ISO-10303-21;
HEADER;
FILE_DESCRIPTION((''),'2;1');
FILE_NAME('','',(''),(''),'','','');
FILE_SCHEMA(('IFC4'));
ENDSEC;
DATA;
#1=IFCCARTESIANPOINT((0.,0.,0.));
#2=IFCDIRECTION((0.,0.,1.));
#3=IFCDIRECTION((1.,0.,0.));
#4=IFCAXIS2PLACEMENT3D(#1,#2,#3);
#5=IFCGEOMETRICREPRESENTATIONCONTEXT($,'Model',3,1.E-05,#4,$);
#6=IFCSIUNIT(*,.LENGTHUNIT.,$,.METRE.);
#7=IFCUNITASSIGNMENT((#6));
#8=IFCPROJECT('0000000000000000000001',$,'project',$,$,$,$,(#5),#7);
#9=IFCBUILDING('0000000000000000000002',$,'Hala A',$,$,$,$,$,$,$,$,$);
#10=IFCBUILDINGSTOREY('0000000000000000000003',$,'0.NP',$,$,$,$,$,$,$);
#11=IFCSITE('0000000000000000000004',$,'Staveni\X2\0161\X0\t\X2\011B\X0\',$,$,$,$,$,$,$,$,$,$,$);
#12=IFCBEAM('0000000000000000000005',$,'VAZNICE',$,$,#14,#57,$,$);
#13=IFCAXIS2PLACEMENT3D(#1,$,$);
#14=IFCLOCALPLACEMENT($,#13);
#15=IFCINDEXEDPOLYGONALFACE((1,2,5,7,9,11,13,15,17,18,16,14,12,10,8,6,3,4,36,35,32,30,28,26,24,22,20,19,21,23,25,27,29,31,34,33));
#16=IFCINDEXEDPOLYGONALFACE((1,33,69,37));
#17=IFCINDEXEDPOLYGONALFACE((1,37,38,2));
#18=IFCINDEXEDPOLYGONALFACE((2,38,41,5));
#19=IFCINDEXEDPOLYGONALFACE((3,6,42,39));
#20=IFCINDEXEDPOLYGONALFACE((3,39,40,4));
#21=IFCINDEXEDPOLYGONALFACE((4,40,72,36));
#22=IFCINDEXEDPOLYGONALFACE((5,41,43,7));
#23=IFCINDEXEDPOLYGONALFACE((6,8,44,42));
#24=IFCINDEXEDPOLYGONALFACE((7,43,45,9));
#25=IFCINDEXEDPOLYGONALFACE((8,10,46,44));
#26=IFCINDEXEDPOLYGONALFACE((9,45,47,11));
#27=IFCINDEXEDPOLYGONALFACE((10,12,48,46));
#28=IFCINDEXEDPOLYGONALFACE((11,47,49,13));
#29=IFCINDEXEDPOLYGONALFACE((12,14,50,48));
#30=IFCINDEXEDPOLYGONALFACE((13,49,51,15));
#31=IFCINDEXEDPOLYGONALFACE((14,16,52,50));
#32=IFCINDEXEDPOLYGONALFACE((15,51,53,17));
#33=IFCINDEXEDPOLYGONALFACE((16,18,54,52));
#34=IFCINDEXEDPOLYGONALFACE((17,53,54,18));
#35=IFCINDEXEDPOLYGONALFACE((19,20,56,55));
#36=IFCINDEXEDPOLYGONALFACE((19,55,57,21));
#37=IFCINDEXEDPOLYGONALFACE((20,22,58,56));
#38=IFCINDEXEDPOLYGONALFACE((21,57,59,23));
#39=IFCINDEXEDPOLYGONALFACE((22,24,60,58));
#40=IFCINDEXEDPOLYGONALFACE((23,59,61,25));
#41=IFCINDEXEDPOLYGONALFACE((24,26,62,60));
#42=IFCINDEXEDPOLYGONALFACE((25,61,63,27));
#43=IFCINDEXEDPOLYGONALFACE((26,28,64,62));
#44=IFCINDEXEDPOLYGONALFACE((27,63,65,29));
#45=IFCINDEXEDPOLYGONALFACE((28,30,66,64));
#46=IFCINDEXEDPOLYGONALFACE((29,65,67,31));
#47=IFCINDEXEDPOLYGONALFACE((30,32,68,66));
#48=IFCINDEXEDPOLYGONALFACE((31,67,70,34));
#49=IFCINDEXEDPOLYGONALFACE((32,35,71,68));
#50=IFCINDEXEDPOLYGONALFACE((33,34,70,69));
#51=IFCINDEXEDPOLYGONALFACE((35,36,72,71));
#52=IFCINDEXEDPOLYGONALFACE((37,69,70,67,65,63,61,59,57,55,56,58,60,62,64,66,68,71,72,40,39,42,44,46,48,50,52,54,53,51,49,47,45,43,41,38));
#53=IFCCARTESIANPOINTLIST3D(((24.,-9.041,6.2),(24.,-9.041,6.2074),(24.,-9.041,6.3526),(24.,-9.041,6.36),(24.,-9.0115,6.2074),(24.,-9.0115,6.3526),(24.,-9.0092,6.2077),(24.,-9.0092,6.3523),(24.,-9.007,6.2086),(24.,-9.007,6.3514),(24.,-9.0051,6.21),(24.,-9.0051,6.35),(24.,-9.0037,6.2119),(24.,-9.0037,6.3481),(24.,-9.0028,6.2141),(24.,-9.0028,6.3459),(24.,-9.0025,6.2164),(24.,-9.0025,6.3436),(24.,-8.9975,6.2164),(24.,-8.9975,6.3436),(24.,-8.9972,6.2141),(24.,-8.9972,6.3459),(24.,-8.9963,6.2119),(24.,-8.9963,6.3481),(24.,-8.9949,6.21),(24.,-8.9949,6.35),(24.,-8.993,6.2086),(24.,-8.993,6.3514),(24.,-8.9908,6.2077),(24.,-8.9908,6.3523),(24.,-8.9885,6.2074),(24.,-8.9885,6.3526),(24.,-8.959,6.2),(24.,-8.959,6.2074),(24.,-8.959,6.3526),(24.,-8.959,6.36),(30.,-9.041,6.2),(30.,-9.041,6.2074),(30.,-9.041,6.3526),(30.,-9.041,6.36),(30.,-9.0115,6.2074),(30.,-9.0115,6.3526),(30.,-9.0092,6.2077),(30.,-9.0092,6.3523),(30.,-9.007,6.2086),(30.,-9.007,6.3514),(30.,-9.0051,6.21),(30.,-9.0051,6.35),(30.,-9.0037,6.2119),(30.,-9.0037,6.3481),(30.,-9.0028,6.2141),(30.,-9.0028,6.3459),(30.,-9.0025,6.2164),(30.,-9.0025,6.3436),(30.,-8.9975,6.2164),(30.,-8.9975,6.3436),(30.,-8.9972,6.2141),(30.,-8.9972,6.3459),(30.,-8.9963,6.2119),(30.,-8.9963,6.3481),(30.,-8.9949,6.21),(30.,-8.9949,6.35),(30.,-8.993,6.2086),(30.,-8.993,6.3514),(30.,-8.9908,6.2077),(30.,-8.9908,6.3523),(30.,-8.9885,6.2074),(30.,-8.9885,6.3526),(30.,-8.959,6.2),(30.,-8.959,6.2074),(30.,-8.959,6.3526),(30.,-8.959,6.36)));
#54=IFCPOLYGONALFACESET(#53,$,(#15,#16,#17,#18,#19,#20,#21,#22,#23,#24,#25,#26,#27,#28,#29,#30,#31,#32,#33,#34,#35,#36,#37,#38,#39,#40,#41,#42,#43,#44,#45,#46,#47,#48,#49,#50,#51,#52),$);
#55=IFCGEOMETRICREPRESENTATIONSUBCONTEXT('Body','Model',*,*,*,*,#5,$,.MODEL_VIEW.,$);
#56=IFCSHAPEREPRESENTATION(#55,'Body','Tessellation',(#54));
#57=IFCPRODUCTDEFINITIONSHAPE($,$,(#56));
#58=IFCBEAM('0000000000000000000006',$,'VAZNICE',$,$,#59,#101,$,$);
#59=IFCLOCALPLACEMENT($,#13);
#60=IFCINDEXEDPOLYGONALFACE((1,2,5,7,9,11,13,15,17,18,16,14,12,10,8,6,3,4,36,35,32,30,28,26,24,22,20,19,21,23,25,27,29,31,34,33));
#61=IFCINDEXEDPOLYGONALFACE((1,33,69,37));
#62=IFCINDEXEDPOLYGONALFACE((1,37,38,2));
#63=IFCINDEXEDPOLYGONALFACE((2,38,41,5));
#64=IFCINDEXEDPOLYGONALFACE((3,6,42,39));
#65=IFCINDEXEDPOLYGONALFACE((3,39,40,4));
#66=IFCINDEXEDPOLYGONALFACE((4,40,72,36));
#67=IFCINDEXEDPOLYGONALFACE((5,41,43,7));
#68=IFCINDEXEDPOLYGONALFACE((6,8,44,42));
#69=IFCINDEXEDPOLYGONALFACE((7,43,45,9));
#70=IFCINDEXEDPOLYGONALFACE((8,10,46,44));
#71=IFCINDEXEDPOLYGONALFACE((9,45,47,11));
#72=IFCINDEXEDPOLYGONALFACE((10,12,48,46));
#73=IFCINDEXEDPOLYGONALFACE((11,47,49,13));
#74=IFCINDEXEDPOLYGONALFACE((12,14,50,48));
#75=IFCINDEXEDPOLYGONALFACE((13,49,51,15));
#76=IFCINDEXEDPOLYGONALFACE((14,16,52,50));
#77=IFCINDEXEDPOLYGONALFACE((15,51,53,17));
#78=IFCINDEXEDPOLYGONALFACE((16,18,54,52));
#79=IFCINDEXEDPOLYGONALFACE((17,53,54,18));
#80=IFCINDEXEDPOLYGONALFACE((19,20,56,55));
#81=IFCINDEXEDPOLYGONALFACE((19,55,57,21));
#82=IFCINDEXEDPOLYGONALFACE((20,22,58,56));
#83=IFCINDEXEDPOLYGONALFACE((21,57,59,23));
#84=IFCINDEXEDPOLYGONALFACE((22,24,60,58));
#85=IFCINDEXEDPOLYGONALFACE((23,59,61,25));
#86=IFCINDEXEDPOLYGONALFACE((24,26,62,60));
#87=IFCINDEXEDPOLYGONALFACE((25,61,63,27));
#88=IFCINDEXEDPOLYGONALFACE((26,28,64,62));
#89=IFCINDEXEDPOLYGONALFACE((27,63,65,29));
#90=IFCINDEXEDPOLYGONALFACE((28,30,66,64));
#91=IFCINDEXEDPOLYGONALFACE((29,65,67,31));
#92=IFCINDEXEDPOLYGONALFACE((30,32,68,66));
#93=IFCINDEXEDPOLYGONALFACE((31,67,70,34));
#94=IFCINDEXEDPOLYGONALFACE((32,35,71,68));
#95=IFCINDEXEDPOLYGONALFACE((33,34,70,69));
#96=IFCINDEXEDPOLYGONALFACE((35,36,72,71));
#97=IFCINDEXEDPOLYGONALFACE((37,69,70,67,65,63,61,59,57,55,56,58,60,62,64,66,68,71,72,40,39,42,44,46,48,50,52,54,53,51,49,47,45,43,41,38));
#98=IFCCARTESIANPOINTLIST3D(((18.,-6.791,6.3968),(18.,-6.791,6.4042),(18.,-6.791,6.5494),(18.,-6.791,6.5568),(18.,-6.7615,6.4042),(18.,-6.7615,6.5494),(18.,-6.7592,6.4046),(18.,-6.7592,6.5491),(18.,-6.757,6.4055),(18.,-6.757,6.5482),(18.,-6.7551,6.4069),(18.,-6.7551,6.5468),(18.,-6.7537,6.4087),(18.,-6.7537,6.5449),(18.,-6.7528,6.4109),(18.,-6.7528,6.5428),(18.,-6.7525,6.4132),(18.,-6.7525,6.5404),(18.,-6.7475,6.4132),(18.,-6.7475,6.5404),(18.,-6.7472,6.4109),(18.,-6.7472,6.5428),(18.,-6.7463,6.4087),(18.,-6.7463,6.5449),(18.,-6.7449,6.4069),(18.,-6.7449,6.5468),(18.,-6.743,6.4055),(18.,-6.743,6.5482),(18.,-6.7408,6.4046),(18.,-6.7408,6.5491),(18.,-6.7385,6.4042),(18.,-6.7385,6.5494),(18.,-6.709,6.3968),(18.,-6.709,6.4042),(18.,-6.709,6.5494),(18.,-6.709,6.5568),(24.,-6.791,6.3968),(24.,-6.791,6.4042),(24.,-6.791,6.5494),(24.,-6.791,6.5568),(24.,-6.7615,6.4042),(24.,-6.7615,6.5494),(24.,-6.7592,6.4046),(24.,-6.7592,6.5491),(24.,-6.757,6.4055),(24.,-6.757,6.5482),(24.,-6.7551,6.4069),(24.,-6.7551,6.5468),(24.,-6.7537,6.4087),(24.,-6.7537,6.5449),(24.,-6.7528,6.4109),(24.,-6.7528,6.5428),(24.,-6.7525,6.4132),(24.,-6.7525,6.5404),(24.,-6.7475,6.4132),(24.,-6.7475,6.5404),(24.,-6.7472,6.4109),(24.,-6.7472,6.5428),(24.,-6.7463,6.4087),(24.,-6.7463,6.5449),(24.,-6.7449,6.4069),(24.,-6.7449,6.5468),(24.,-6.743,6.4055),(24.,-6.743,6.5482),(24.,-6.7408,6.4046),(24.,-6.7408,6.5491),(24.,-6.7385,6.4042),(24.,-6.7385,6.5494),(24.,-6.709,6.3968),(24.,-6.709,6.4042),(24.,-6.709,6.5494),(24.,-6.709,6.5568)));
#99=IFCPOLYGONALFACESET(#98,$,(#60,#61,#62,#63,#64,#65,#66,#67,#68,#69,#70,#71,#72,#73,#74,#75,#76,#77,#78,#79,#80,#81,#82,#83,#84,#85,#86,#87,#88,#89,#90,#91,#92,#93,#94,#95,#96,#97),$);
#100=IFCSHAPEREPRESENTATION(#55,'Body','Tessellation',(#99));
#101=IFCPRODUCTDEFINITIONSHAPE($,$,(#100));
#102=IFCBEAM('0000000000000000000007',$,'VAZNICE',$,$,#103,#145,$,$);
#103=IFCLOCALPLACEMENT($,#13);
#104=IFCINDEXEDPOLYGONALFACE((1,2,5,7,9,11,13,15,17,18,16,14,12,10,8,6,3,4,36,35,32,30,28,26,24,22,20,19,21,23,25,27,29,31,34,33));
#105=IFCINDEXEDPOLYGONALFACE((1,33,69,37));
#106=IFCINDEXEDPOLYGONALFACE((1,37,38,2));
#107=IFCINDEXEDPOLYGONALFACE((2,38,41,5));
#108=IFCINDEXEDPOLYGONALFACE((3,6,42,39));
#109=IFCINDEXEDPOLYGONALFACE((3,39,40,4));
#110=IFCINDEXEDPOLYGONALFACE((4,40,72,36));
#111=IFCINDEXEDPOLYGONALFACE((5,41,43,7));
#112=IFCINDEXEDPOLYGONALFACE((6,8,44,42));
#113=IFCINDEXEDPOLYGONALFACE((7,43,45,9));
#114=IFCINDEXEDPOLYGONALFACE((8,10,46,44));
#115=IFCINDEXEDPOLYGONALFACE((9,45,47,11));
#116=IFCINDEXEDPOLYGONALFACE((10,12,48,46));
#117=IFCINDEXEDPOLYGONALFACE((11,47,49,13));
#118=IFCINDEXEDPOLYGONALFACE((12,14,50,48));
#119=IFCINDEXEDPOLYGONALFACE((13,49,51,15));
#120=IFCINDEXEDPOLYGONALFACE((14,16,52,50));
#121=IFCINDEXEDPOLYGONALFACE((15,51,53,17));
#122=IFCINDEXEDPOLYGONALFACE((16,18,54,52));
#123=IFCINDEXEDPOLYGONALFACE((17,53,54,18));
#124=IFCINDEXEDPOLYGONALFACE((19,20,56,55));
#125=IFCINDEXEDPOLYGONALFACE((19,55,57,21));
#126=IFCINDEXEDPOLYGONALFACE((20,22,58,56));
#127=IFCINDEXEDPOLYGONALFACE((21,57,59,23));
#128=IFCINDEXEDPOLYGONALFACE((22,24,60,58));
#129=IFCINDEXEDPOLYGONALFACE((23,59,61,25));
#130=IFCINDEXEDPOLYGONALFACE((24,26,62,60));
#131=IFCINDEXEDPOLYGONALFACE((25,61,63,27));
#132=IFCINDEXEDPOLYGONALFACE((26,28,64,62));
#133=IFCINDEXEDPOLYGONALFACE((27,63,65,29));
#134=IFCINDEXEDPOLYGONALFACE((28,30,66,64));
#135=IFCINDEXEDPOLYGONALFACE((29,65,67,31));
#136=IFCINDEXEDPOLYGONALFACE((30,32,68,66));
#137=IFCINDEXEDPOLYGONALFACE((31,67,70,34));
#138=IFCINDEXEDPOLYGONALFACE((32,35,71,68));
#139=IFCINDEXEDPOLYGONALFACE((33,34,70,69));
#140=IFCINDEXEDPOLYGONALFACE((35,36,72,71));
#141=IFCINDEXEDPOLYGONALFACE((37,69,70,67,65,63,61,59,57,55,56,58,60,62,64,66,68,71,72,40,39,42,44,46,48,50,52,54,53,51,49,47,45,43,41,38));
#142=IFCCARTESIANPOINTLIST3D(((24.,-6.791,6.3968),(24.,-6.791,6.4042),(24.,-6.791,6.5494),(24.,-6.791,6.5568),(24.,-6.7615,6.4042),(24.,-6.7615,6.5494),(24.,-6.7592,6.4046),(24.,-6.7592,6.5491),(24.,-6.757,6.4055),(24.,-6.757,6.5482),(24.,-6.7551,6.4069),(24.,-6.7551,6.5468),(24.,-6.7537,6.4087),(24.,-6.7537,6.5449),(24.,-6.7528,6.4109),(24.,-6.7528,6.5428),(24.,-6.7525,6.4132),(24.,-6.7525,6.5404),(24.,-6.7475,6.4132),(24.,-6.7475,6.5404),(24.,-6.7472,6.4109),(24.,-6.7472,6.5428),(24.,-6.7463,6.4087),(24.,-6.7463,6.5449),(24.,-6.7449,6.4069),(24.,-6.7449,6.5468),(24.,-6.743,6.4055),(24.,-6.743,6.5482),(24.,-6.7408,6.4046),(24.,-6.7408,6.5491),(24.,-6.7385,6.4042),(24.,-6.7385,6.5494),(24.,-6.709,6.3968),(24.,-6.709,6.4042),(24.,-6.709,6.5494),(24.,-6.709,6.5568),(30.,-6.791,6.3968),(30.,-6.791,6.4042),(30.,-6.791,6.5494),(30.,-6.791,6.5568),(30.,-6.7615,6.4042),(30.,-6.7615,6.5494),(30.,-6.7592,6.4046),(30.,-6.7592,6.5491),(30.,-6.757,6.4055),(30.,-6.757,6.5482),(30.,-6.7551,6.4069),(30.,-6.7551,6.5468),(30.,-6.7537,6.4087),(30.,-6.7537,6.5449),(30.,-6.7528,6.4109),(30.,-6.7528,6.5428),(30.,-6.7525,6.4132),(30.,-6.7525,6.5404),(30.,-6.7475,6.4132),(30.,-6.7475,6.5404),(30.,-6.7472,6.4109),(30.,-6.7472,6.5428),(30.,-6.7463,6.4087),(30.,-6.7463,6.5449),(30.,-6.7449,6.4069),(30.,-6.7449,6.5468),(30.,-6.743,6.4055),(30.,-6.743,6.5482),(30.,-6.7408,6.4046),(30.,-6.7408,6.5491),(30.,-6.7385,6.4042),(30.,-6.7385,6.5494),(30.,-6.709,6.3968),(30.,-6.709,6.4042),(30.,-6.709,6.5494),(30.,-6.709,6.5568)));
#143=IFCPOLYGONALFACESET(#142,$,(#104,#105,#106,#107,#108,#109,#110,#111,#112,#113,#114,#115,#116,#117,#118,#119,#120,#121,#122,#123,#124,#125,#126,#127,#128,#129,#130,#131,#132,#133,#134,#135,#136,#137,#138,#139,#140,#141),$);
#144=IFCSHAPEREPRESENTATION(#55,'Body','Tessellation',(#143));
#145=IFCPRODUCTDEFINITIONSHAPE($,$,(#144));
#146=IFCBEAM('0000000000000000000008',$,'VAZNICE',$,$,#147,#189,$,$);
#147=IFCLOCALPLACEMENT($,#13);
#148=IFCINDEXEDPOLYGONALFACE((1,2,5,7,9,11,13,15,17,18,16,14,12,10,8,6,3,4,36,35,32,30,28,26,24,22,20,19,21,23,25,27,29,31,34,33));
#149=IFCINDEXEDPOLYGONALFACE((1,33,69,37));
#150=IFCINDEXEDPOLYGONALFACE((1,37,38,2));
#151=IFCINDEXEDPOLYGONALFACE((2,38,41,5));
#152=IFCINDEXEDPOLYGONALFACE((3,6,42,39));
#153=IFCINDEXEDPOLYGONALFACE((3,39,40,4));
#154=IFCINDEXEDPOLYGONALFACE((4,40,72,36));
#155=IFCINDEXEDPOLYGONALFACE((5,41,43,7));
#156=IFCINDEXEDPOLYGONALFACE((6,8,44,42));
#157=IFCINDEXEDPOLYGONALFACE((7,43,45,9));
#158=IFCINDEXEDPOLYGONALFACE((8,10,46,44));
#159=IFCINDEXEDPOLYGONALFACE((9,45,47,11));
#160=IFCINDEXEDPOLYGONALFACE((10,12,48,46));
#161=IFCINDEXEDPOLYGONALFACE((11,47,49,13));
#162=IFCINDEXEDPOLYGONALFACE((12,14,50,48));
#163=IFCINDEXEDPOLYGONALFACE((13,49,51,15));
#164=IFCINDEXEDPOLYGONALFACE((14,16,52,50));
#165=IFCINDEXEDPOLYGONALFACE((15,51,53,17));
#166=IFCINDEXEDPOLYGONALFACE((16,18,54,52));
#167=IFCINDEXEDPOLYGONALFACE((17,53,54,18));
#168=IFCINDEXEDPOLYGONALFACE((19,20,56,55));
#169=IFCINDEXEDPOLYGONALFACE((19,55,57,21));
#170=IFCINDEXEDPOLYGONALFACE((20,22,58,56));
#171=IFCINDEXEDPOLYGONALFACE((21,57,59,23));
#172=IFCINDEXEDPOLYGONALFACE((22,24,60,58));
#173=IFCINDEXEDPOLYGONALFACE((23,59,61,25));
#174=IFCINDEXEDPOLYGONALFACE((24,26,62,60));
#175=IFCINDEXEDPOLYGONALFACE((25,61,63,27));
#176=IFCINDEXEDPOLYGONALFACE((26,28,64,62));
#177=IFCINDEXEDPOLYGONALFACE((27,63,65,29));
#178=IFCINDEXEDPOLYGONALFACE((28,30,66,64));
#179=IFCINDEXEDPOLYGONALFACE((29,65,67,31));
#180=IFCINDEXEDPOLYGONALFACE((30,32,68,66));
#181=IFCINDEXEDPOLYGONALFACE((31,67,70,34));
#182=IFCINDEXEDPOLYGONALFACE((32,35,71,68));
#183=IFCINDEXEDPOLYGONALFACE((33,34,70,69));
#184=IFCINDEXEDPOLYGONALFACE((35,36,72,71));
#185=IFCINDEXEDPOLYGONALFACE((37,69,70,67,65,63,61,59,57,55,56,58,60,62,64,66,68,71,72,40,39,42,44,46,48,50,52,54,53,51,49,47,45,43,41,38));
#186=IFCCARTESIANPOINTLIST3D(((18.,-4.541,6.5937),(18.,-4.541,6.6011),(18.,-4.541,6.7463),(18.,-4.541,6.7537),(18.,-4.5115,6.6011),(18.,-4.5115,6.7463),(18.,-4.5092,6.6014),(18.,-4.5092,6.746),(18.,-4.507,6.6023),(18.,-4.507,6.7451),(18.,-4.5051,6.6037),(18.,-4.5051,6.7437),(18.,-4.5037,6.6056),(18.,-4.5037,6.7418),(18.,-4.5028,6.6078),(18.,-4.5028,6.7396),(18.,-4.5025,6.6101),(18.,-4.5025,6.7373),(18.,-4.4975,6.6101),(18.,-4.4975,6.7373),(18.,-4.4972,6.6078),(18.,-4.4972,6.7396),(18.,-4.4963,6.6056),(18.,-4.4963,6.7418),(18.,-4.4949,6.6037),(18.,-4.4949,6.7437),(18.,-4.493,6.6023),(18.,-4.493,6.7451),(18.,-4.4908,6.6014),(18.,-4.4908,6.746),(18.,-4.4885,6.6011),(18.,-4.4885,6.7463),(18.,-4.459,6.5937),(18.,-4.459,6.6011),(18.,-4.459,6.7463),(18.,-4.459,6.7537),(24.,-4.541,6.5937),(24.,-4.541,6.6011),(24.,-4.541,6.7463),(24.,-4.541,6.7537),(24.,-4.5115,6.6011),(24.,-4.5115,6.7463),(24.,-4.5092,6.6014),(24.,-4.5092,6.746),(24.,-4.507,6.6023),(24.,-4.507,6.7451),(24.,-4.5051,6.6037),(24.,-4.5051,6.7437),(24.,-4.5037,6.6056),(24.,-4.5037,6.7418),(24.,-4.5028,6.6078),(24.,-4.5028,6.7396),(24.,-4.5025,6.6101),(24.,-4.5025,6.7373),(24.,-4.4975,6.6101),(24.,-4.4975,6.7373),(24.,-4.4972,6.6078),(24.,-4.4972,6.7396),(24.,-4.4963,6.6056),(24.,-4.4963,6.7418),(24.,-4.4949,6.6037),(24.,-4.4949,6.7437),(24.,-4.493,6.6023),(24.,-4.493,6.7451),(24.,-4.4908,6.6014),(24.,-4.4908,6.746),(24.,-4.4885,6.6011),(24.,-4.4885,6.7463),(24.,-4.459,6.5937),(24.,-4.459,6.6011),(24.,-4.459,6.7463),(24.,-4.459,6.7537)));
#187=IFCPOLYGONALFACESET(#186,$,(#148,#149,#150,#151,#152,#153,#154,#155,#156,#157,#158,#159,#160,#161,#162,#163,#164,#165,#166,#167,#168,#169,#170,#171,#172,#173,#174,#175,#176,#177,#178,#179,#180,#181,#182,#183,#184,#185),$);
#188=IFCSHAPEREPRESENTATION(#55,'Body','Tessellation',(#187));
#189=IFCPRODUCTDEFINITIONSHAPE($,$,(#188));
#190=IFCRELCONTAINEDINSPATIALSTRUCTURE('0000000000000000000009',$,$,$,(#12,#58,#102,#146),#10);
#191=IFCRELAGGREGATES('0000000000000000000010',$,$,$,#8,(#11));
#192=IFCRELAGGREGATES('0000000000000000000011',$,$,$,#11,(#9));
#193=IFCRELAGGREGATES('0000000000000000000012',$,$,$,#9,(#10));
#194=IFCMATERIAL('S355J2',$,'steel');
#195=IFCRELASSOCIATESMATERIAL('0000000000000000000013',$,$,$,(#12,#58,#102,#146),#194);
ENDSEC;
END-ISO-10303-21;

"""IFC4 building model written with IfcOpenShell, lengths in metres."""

from ifc_helpers import new_model, si_unit, frame, origin_with_axes, place, context, subcontext, project, spatial, i_section, extrude, material, element, save


model = new_model("IFC4")

# Units and contexts
model_context = context("Model", 3, precision=1e-05, world=origin_with_axes())
body_context = subcontext(model_context, "Body", "Model", "MODEL_VIEW")
ifc_project = project(units=[si_unit("LENGTHUNIT", "METRE")], contexts=[model_context])

# Site, building, storey
site = spatial("IfcSite", under=ifc_project, Name="Staveniště")
building = spatial("IfcBuilding", under=site, Name="Hala A")
storey = spatial("IfcBuildingStorey", under=building, Name="0.NP")

# Shared definitions
ifc_material = material(Name="S355J2", Category="steel")

# Beams
for number, where, z_axis, x_axis, name in (
    (1, (24.0, -9.0, 6.28), (1.0, 0.0, 0.0), (0.0, 1.0, 0.0), "VAZNICE"),
    (2, (18.0, -6.75, 6.4768), (1.0, 0.0, 0.0), (0.0, 1.0, 0.0), "VAZNICE"),
    (3, (24.0, -6.75, 6.4768), (1.0, 0.0, 0.0), (0.0, 1.0, 0.0), "VAZNICE"),
    (4, (18.0, -4.5, 6.6737), (1.0, 0.0, 0.0), (0.0, 1.0, 0.0), "VAZNICE"),
):
    element("IfcBeam", number, at=place(None, frame(where, z_axis=z_axis, x_axis=x_axis)), inside=storey, material=ifc_material, Name=name, context=body_context, shape_type="SweptSolid", body=[
        extrude(i_section(OverallWidth=0.082, OverallDepth=0.16, WebThickness=0.005, FlangeThickness=0.0074, FilletRadius=0.009), origin_with_axes(), (0.0, 0.0, 1.0), 6.0),
    ])

save(model, "model.ifc")
